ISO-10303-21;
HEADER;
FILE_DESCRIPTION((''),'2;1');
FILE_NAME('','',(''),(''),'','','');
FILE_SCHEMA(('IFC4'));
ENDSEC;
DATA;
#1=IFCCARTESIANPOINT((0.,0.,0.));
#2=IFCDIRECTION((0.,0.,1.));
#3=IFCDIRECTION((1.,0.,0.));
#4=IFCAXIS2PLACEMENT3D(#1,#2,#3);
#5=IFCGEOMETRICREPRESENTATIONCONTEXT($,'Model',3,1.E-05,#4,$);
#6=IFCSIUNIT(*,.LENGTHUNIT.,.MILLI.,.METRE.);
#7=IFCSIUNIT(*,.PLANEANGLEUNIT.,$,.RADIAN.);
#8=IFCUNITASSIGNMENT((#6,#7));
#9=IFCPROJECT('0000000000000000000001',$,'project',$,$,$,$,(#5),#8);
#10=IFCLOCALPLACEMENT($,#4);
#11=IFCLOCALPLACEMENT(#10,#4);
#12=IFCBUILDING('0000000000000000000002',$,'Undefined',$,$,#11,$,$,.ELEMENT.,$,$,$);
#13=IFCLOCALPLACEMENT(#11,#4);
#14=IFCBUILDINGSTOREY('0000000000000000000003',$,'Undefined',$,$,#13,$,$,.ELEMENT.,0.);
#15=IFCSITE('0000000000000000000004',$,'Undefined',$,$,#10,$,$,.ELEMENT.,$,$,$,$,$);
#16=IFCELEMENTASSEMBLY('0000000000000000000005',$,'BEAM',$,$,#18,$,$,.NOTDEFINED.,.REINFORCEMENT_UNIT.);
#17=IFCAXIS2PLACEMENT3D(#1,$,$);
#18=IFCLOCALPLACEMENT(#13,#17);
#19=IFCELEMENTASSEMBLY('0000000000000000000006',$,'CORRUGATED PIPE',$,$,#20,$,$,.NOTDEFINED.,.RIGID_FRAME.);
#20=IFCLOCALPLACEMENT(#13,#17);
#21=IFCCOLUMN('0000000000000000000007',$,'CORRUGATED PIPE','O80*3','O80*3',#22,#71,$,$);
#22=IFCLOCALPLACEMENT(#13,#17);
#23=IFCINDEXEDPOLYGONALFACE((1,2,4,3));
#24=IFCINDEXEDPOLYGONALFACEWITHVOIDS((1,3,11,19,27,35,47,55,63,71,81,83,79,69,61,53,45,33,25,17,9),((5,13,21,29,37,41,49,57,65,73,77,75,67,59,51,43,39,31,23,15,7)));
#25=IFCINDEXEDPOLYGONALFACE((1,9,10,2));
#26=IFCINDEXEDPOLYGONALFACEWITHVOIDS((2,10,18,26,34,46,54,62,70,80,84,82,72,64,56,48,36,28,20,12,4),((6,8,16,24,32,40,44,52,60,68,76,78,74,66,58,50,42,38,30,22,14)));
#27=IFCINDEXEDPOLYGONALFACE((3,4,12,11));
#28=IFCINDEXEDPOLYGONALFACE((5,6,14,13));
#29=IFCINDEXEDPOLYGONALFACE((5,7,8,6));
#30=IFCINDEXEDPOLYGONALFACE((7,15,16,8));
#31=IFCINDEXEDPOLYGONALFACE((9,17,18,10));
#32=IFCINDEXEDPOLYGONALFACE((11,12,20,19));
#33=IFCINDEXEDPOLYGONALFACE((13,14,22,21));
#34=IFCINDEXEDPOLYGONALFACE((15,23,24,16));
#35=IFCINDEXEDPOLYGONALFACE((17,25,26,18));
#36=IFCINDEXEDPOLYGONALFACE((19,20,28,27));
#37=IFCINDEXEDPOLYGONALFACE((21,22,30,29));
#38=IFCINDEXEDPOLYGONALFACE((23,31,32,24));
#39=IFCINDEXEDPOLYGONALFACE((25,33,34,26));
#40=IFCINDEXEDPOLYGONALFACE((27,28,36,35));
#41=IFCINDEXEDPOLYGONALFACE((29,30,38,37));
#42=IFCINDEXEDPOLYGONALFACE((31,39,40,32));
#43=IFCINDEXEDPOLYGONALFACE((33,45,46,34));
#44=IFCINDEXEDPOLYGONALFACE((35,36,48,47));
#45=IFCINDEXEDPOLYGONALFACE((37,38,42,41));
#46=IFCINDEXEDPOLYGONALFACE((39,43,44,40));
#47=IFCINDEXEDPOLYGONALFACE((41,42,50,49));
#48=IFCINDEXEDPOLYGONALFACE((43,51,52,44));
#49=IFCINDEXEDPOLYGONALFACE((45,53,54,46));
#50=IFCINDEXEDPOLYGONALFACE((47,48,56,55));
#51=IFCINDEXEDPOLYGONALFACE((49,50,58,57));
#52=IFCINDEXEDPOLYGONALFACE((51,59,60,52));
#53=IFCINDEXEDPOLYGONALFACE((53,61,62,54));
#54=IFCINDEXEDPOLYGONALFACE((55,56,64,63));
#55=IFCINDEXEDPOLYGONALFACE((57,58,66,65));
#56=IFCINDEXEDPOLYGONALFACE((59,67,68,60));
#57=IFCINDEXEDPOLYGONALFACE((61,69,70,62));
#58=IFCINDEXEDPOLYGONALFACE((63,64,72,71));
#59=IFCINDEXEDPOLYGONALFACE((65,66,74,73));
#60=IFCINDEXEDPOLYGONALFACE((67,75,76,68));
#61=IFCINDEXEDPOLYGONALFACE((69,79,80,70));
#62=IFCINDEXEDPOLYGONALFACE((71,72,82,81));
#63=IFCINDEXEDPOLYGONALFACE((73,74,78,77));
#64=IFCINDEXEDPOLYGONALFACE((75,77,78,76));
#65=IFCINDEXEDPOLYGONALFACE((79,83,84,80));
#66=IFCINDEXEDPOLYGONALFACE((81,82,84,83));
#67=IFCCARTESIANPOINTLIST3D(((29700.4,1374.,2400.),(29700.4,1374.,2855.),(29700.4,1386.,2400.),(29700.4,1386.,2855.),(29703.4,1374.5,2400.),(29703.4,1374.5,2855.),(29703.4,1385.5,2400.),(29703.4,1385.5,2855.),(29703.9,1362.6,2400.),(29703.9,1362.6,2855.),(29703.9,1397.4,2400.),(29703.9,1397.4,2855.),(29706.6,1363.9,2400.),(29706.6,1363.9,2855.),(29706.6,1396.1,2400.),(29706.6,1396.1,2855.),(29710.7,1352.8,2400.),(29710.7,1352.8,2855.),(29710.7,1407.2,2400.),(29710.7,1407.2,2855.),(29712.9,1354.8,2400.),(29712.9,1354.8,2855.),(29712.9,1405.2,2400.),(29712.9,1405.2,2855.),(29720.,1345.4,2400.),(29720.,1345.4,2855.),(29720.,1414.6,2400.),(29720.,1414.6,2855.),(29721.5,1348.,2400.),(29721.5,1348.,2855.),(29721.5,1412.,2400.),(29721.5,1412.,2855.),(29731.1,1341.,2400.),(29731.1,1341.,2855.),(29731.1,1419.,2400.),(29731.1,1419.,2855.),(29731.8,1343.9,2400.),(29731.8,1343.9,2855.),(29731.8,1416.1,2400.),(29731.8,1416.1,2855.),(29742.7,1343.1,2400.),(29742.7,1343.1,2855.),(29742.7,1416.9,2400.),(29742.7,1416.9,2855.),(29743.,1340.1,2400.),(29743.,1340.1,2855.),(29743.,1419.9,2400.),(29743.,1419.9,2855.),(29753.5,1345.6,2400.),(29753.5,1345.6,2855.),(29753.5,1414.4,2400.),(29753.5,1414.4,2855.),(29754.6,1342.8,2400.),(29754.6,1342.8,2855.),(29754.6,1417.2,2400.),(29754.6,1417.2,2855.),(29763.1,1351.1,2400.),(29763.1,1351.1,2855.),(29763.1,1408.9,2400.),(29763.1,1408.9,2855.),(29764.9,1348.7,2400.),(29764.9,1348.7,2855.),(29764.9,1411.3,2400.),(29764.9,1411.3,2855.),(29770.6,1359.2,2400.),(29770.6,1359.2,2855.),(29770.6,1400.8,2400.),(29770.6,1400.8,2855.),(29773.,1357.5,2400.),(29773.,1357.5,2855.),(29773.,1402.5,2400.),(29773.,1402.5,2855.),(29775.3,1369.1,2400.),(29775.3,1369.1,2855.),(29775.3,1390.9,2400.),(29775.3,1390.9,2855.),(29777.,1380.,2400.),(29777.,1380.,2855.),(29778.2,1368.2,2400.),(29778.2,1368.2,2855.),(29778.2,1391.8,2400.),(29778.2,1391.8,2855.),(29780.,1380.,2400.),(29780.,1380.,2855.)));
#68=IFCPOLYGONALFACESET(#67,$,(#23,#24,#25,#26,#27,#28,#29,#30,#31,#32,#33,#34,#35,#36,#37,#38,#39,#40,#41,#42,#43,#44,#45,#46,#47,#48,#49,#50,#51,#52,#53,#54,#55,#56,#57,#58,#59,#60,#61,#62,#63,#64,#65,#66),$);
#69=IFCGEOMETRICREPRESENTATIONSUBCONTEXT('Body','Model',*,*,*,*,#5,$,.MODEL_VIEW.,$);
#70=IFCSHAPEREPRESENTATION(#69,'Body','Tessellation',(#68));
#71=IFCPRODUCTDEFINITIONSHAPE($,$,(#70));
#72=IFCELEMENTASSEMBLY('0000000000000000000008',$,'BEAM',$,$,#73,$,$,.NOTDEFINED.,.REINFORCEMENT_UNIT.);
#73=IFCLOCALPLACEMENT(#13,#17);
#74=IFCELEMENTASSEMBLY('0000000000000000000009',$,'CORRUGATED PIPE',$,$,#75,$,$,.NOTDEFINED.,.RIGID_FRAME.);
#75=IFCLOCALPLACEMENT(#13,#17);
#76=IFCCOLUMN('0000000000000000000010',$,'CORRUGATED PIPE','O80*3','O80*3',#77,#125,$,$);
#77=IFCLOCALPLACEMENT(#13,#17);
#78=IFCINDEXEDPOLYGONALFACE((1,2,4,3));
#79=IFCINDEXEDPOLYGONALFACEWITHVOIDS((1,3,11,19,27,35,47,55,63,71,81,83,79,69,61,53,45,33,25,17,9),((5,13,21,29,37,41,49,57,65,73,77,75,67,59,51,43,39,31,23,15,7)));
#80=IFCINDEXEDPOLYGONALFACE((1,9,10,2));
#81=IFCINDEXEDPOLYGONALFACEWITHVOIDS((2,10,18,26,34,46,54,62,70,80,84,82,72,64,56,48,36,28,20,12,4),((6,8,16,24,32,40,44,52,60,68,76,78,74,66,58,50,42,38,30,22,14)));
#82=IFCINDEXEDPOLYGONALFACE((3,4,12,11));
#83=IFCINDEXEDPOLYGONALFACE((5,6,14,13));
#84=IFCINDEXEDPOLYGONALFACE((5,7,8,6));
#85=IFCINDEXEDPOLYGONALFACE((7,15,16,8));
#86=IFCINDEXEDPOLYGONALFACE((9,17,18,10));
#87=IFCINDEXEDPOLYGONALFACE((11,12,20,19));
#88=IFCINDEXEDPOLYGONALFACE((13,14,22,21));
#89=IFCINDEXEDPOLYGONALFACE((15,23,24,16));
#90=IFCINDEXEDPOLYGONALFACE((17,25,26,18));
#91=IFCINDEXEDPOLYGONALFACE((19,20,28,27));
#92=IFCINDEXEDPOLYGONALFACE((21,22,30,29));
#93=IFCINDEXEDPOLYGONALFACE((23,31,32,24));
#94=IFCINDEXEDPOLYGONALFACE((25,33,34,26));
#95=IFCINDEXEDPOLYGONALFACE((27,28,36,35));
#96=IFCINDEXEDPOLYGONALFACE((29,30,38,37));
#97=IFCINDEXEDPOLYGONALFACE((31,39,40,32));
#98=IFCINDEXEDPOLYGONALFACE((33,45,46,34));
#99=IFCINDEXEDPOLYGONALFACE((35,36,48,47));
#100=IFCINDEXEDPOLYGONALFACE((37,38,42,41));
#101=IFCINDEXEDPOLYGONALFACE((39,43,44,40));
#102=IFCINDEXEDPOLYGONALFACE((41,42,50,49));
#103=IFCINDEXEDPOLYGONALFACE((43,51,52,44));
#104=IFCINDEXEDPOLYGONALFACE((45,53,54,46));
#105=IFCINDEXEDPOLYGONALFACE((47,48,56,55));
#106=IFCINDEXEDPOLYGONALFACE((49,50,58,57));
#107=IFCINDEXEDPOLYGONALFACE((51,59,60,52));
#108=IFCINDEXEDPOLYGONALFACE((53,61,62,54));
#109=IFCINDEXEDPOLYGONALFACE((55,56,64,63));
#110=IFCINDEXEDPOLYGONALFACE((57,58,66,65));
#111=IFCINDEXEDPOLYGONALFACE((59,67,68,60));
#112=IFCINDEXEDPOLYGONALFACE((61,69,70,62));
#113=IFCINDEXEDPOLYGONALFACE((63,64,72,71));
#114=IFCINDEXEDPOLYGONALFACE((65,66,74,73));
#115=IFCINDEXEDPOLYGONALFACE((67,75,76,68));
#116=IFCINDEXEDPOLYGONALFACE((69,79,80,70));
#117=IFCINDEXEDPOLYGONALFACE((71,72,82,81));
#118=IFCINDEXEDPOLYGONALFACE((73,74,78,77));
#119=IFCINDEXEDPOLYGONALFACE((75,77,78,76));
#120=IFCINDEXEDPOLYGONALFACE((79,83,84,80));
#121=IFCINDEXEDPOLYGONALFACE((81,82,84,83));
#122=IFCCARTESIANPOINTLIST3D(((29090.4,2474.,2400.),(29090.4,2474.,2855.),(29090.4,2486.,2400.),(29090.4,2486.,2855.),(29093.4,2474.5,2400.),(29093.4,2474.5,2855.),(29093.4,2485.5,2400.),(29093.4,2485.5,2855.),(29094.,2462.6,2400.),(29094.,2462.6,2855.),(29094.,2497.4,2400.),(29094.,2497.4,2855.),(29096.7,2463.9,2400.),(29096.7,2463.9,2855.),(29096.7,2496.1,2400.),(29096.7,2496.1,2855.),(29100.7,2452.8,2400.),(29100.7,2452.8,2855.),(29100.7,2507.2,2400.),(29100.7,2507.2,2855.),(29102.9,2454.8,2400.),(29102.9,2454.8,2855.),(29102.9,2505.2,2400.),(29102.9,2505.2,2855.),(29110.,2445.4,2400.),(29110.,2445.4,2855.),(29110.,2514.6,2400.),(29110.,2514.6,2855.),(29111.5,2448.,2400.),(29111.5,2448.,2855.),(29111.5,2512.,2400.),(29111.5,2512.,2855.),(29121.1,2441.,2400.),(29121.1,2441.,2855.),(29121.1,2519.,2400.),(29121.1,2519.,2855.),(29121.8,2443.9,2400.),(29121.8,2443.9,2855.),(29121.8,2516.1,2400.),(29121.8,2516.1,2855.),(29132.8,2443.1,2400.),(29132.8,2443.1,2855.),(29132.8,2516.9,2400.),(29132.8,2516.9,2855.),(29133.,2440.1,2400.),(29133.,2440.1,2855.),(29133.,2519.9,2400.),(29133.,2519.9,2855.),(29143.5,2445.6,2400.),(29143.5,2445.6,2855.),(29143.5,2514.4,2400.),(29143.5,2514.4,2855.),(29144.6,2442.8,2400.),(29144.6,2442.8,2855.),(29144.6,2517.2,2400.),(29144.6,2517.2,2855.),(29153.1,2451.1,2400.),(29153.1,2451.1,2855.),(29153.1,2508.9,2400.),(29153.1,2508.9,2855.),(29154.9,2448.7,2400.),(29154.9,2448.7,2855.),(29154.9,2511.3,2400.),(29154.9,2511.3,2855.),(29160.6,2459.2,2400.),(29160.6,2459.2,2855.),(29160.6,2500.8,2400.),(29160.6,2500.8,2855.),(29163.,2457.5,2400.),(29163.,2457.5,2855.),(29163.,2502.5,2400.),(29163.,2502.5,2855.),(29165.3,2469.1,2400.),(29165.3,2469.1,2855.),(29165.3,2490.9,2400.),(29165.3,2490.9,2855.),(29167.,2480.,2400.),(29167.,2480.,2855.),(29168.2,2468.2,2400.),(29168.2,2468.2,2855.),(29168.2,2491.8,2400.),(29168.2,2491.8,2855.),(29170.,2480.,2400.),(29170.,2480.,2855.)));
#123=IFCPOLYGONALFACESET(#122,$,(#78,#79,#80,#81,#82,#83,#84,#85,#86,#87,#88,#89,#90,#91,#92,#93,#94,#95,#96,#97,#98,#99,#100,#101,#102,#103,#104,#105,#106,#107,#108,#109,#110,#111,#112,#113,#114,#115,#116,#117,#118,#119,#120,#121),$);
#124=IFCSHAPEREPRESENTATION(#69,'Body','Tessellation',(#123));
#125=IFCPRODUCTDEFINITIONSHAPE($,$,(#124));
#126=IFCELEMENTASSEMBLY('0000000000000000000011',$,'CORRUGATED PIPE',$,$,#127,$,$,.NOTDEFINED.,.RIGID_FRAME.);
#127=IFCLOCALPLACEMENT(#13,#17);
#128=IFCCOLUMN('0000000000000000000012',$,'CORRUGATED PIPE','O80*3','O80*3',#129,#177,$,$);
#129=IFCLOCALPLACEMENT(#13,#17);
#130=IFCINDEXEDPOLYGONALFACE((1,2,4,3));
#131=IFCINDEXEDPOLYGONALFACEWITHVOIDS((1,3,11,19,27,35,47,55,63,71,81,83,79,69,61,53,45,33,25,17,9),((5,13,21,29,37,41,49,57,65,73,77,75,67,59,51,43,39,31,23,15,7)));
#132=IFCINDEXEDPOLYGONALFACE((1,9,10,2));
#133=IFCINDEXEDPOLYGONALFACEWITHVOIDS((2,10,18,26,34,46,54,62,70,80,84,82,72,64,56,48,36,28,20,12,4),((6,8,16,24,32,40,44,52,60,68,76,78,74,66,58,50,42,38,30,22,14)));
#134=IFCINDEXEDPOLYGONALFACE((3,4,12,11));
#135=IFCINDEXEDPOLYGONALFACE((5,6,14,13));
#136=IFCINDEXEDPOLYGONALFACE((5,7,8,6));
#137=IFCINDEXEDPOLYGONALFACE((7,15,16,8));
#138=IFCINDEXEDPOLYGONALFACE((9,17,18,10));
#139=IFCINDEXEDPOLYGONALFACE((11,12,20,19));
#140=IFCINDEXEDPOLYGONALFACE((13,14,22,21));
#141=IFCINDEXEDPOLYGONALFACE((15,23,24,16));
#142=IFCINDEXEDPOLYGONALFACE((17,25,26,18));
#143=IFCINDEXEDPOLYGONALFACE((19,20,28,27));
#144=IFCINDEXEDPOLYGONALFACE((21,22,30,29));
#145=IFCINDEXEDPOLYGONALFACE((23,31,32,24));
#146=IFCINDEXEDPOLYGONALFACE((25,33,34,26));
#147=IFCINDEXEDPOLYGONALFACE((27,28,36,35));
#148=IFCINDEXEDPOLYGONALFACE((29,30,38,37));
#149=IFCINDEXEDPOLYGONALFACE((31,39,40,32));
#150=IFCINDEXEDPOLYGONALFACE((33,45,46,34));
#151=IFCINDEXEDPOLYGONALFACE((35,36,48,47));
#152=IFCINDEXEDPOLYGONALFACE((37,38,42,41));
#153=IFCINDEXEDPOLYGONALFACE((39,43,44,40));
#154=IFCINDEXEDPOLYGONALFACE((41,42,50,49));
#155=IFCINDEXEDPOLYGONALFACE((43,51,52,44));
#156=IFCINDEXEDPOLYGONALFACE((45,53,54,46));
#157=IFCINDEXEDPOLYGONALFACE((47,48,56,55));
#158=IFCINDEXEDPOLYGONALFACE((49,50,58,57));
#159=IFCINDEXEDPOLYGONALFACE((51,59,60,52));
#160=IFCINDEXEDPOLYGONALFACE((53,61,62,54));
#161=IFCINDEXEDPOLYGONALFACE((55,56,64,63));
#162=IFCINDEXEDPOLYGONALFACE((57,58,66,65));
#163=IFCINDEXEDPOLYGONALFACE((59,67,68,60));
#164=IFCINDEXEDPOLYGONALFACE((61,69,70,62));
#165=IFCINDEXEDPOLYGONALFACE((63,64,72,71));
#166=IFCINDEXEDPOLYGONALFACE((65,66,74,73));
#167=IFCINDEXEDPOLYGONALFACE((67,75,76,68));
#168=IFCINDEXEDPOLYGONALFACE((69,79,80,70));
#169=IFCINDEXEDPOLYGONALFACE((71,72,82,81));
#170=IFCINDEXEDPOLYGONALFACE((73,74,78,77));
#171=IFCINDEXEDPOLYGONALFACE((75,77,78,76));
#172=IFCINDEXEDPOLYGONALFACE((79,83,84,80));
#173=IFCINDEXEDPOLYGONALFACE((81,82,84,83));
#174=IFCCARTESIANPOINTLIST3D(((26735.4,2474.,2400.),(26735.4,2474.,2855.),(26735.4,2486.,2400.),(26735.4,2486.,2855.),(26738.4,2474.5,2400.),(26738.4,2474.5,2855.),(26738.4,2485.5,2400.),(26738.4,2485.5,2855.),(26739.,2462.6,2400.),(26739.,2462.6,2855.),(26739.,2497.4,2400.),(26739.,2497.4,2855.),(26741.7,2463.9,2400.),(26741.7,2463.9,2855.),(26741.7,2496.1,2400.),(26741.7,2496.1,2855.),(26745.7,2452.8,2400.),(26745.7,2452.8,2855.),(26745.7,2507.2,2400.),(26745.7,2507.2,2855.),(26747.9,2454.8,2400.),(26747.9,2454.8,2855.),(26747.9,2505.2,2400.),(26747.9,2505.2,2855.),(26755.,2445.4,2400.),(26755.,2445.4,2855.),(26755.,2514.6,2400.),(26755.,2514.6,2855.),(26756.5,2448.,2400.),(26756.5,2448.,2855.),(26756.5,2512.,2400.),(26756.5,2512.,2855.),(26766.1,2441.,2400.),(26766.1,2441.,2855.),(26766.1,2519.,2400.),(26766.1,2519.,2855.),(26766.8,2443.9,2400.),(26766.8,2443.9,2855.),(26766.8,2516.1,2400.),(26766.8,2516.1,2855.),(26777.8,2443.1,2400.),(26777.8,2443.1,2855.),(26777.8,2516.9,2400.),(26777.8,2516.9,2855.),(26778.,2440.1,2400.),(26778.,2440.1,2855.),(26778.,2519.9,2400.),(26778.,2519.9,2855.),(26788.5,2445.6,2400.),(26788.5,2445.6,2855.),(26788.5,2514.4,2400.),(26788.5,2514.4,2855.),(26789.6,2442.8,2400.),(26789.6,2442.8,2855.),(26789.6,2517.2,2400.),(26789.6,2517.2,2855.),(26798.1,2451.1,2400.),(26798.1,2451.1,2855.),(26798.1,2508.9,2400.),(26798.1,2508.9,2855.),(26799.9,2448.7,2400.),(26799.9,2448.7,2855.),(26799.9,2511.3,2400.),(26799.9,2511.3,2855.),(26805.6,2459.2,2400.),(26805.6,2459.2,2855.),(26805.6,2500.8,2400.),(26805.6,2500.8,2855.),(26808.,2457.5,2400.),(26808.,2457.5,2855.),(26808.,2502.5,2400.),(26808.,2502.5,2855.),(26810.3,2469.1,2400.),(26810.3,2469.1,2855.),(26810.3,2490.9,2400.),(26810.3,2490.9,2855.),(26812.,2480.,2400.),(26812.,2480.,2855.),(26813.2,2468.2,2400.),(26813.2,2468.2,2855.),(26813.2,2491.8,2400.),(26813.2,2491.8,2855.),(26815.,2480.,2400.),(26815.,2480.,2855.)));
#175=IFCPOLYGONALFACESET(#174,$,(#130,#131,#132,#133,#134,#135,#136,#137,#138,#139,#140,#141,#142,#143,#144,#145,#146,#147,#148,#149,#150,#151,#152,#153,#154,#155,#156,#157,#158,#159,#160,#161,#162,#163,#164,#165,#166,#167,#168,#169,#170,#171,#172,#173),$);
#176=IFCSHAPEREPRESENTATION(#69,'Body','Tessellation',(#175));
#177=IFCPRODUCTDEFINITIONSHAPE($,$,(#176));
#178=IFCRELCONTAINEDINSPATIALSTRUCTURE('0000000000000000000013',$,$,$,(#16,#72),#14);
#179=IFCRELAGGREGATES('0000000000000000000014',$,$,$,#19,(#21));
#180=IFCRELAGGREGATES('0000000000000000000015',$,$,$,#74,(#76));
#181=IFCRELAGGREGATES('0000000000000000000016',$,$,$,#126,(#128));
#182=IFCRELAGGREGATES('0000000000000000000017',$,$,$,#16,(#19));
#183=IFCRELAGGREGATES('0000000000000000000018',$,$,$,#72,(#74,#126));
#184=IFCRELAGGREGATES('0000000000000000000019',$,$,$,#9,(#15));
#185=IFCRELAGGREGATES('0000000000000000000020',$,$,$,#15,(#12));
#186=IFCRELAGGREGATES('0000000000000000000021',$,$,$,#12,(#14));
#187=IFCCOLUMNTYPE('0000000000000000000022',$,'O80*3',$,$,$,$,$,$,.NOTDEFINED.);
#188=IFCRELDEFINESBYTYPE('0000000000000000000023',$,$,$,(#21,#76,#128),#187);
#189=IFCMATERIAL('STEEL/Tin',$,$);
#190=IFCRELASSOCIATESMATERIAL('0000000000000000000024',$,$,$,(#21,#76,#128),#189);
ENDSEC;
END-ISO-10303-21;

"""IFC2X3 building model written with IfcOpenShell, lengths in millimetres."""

from ifc_helpers import new_model, si_unit, frame, origin_with_axes, origin_2d_with_axis, place, context, subcontext, project, spatial, hollow_circle, extrude, material, type_object, element, aggregate, save


model = new_model("IFC2X3")

# Units and contexts
model_context = context("Model", 3, precision=1e-05, world=origin_with_axes())
body_context = subcontext(model_context, "Body", "Model", "MODEL_VIEW")
ifc_project = project(units=[si_unit("LENGTHUNIT", "METRE", prefix="MILLI"), si_unit("PLANEANGLEUNIT", "RADIAN")], contexts=[model_context])

# Site, building, storey
site_placement = place(None, origin_with_axes())
site = spatial("IfcSite", under=ifc_project, at=site_placement, Name="Undefined", CompositionType="ELEMENT")
building_placement = place(site_placement, origin_with_axes())
building = spatial("IfcBuilding", under=site, at=building_placement, Name="Undefined", CompositionType="ELEMENT")
storey_placement = place(building_placement, origin_with_axes())
storey = spatial("IfcBuildingStorey", under=building, at=storey_placement, Name="Undefined", CompositionType="ELEMENT", Elevation=0.0)

# Element assemblies, column
assembly_1_placement = place(storey_placement, origin_with_axes())
assembly_1 = element("IfcElementAssembly", 1, at=assembly_1_placement, inside=storey, Name="BEAM", AssemblyPlace="NOTDEFINED", PredefinedType="REINFORCEMENT_UNIT")
assembly_2_placement = place(assembly_1_placement, origin_with_axes())
assembly_2 = element("IfcElementAssembly", 2, at=assembly_2_placement, Name="CORRUGATED PIPE", AssemblyPlace="NOTDEFINED", PredefinedType="RIGID_FRAME")
ifc_material_1 = material(Name="STEEL/Tin")
column_type = type_object("IfcColumnType", Name="O80*3", PredefinedType="NOTDEFINED")
column_1_placement = place(assembly_2_placement, frame((29740.0, 1380.0, 2400.0), z_axis=(0.0, 0.0, 1.0), x_axis=(0.0, -1.0, 0.0)))
column_1 = element("IfcColumn", 3, at=column_1_placement, type_object=column_type, material=ifc_material_1, Name="CORRUGATED PIPE", Description="O80*3", ObjectType="O80*3", context=body_context, shape_type="SweptSolid", body=[
    extrude(hollow_circle(Radius=40.0, WallThickness=3.0, at=origin_2d_with_axis()), frame((0.0, 0.0, 455.0), z_axis=(0.0, 0.0, -1.0), x_axis=(0.0, 1.0, 0.0)), (0.0, 0.0, 1.0), 455.0),
])
aggregate(assembly_2, [column_1])

# Element assemblies, columns
assembly_3_placement = place(storey_placement, origin_with_axes())
assembly_3 = element("IfcElementAssembly", 4, at=assembly_3_placement, inside=storey, Name="BEAM", AssemblyPlace="NOTDEFINED", PredefinedType="REINFORCEMENT_UNIT")
assembly_4_placement = place(assembly_3_placement, origin_with_axes())
assembly_4 = element("IfcElementAssembly", 5, at=assembly_4_placement, Name="CORRUGATED PIPE", AssemblyPlace="NOTDEFINED", PredefinedType="RIGID_FRAME")
column_2_placement = place(assembly_4_placement, frame((29130.0, 2480.0, 2400.0), z_axis=(0.0, 0.0, 1.0), x_axis=(0.0, -1.0, 0.0)))
column_2 = element("IfcColumn", 6, at=column_2_placement, type_object=column_type, material=ifc_material_1, Name="CORRUGATED PIPE", Description="O80*3", ObjectType="O80*3", context=body_context, shape_type="SweptSolid", body=[
    extrude(hollow_circle(Radius=40.0, WallThickness=3.0, at=origin_2d_with_axis()), frame((0.0, 0.0, 455.0), z_axis=(0.0, 0.0, -1.0), x_axis=(0.0, 1.0, 0.0)), (0.0, 0.0, 1.0), 455.0),
])
aggregate(assembly_4, [column_2])
assembly_5_placement = place(assembly_3_placement, origin_with_axes())
assembly_5 = element("IfcElementAssembly", 7, at=assembly_5_placement, Name="CORRUGATED PIPE", AssemblyPlace="NOTDEFINED", PredefinedType="RIGID_FRAME")
column_3_placement = place(assembly_5_placement, frame((26775.0, 2480.0, 2400.0), z_axis=(0.0, 0.0, 1.0), x_axis=(0.0, -1.0, 0.0)))
column_3 = element("IfcColumn", 8, at=column_3_placement, type_object=column_type, material=ifc_material_1, Name="CORRUGATED PIPE", Description="O80*3", ObjectType="O80*3", context=body_context, shape_type="SweptSolid", body=[
    extrude(hollow_circle(Radius=40.0, WallThickness=3.0, at=origin_2d_with_axis()), frame((0.0, 0.0, 455.0), z_axis=(0.0, 0.0, -1.0), x_axis=(0.0, 1.0, 0.0)), (0.0, 0.0, 1.0), 455.0),
])
aggregate(assembly_5, [column_3])

aggregate(assembly_1, [assembly_2])
aggregate(assembly_3, [assembly_4, assembly_5])

save(model, "model.ifc")
